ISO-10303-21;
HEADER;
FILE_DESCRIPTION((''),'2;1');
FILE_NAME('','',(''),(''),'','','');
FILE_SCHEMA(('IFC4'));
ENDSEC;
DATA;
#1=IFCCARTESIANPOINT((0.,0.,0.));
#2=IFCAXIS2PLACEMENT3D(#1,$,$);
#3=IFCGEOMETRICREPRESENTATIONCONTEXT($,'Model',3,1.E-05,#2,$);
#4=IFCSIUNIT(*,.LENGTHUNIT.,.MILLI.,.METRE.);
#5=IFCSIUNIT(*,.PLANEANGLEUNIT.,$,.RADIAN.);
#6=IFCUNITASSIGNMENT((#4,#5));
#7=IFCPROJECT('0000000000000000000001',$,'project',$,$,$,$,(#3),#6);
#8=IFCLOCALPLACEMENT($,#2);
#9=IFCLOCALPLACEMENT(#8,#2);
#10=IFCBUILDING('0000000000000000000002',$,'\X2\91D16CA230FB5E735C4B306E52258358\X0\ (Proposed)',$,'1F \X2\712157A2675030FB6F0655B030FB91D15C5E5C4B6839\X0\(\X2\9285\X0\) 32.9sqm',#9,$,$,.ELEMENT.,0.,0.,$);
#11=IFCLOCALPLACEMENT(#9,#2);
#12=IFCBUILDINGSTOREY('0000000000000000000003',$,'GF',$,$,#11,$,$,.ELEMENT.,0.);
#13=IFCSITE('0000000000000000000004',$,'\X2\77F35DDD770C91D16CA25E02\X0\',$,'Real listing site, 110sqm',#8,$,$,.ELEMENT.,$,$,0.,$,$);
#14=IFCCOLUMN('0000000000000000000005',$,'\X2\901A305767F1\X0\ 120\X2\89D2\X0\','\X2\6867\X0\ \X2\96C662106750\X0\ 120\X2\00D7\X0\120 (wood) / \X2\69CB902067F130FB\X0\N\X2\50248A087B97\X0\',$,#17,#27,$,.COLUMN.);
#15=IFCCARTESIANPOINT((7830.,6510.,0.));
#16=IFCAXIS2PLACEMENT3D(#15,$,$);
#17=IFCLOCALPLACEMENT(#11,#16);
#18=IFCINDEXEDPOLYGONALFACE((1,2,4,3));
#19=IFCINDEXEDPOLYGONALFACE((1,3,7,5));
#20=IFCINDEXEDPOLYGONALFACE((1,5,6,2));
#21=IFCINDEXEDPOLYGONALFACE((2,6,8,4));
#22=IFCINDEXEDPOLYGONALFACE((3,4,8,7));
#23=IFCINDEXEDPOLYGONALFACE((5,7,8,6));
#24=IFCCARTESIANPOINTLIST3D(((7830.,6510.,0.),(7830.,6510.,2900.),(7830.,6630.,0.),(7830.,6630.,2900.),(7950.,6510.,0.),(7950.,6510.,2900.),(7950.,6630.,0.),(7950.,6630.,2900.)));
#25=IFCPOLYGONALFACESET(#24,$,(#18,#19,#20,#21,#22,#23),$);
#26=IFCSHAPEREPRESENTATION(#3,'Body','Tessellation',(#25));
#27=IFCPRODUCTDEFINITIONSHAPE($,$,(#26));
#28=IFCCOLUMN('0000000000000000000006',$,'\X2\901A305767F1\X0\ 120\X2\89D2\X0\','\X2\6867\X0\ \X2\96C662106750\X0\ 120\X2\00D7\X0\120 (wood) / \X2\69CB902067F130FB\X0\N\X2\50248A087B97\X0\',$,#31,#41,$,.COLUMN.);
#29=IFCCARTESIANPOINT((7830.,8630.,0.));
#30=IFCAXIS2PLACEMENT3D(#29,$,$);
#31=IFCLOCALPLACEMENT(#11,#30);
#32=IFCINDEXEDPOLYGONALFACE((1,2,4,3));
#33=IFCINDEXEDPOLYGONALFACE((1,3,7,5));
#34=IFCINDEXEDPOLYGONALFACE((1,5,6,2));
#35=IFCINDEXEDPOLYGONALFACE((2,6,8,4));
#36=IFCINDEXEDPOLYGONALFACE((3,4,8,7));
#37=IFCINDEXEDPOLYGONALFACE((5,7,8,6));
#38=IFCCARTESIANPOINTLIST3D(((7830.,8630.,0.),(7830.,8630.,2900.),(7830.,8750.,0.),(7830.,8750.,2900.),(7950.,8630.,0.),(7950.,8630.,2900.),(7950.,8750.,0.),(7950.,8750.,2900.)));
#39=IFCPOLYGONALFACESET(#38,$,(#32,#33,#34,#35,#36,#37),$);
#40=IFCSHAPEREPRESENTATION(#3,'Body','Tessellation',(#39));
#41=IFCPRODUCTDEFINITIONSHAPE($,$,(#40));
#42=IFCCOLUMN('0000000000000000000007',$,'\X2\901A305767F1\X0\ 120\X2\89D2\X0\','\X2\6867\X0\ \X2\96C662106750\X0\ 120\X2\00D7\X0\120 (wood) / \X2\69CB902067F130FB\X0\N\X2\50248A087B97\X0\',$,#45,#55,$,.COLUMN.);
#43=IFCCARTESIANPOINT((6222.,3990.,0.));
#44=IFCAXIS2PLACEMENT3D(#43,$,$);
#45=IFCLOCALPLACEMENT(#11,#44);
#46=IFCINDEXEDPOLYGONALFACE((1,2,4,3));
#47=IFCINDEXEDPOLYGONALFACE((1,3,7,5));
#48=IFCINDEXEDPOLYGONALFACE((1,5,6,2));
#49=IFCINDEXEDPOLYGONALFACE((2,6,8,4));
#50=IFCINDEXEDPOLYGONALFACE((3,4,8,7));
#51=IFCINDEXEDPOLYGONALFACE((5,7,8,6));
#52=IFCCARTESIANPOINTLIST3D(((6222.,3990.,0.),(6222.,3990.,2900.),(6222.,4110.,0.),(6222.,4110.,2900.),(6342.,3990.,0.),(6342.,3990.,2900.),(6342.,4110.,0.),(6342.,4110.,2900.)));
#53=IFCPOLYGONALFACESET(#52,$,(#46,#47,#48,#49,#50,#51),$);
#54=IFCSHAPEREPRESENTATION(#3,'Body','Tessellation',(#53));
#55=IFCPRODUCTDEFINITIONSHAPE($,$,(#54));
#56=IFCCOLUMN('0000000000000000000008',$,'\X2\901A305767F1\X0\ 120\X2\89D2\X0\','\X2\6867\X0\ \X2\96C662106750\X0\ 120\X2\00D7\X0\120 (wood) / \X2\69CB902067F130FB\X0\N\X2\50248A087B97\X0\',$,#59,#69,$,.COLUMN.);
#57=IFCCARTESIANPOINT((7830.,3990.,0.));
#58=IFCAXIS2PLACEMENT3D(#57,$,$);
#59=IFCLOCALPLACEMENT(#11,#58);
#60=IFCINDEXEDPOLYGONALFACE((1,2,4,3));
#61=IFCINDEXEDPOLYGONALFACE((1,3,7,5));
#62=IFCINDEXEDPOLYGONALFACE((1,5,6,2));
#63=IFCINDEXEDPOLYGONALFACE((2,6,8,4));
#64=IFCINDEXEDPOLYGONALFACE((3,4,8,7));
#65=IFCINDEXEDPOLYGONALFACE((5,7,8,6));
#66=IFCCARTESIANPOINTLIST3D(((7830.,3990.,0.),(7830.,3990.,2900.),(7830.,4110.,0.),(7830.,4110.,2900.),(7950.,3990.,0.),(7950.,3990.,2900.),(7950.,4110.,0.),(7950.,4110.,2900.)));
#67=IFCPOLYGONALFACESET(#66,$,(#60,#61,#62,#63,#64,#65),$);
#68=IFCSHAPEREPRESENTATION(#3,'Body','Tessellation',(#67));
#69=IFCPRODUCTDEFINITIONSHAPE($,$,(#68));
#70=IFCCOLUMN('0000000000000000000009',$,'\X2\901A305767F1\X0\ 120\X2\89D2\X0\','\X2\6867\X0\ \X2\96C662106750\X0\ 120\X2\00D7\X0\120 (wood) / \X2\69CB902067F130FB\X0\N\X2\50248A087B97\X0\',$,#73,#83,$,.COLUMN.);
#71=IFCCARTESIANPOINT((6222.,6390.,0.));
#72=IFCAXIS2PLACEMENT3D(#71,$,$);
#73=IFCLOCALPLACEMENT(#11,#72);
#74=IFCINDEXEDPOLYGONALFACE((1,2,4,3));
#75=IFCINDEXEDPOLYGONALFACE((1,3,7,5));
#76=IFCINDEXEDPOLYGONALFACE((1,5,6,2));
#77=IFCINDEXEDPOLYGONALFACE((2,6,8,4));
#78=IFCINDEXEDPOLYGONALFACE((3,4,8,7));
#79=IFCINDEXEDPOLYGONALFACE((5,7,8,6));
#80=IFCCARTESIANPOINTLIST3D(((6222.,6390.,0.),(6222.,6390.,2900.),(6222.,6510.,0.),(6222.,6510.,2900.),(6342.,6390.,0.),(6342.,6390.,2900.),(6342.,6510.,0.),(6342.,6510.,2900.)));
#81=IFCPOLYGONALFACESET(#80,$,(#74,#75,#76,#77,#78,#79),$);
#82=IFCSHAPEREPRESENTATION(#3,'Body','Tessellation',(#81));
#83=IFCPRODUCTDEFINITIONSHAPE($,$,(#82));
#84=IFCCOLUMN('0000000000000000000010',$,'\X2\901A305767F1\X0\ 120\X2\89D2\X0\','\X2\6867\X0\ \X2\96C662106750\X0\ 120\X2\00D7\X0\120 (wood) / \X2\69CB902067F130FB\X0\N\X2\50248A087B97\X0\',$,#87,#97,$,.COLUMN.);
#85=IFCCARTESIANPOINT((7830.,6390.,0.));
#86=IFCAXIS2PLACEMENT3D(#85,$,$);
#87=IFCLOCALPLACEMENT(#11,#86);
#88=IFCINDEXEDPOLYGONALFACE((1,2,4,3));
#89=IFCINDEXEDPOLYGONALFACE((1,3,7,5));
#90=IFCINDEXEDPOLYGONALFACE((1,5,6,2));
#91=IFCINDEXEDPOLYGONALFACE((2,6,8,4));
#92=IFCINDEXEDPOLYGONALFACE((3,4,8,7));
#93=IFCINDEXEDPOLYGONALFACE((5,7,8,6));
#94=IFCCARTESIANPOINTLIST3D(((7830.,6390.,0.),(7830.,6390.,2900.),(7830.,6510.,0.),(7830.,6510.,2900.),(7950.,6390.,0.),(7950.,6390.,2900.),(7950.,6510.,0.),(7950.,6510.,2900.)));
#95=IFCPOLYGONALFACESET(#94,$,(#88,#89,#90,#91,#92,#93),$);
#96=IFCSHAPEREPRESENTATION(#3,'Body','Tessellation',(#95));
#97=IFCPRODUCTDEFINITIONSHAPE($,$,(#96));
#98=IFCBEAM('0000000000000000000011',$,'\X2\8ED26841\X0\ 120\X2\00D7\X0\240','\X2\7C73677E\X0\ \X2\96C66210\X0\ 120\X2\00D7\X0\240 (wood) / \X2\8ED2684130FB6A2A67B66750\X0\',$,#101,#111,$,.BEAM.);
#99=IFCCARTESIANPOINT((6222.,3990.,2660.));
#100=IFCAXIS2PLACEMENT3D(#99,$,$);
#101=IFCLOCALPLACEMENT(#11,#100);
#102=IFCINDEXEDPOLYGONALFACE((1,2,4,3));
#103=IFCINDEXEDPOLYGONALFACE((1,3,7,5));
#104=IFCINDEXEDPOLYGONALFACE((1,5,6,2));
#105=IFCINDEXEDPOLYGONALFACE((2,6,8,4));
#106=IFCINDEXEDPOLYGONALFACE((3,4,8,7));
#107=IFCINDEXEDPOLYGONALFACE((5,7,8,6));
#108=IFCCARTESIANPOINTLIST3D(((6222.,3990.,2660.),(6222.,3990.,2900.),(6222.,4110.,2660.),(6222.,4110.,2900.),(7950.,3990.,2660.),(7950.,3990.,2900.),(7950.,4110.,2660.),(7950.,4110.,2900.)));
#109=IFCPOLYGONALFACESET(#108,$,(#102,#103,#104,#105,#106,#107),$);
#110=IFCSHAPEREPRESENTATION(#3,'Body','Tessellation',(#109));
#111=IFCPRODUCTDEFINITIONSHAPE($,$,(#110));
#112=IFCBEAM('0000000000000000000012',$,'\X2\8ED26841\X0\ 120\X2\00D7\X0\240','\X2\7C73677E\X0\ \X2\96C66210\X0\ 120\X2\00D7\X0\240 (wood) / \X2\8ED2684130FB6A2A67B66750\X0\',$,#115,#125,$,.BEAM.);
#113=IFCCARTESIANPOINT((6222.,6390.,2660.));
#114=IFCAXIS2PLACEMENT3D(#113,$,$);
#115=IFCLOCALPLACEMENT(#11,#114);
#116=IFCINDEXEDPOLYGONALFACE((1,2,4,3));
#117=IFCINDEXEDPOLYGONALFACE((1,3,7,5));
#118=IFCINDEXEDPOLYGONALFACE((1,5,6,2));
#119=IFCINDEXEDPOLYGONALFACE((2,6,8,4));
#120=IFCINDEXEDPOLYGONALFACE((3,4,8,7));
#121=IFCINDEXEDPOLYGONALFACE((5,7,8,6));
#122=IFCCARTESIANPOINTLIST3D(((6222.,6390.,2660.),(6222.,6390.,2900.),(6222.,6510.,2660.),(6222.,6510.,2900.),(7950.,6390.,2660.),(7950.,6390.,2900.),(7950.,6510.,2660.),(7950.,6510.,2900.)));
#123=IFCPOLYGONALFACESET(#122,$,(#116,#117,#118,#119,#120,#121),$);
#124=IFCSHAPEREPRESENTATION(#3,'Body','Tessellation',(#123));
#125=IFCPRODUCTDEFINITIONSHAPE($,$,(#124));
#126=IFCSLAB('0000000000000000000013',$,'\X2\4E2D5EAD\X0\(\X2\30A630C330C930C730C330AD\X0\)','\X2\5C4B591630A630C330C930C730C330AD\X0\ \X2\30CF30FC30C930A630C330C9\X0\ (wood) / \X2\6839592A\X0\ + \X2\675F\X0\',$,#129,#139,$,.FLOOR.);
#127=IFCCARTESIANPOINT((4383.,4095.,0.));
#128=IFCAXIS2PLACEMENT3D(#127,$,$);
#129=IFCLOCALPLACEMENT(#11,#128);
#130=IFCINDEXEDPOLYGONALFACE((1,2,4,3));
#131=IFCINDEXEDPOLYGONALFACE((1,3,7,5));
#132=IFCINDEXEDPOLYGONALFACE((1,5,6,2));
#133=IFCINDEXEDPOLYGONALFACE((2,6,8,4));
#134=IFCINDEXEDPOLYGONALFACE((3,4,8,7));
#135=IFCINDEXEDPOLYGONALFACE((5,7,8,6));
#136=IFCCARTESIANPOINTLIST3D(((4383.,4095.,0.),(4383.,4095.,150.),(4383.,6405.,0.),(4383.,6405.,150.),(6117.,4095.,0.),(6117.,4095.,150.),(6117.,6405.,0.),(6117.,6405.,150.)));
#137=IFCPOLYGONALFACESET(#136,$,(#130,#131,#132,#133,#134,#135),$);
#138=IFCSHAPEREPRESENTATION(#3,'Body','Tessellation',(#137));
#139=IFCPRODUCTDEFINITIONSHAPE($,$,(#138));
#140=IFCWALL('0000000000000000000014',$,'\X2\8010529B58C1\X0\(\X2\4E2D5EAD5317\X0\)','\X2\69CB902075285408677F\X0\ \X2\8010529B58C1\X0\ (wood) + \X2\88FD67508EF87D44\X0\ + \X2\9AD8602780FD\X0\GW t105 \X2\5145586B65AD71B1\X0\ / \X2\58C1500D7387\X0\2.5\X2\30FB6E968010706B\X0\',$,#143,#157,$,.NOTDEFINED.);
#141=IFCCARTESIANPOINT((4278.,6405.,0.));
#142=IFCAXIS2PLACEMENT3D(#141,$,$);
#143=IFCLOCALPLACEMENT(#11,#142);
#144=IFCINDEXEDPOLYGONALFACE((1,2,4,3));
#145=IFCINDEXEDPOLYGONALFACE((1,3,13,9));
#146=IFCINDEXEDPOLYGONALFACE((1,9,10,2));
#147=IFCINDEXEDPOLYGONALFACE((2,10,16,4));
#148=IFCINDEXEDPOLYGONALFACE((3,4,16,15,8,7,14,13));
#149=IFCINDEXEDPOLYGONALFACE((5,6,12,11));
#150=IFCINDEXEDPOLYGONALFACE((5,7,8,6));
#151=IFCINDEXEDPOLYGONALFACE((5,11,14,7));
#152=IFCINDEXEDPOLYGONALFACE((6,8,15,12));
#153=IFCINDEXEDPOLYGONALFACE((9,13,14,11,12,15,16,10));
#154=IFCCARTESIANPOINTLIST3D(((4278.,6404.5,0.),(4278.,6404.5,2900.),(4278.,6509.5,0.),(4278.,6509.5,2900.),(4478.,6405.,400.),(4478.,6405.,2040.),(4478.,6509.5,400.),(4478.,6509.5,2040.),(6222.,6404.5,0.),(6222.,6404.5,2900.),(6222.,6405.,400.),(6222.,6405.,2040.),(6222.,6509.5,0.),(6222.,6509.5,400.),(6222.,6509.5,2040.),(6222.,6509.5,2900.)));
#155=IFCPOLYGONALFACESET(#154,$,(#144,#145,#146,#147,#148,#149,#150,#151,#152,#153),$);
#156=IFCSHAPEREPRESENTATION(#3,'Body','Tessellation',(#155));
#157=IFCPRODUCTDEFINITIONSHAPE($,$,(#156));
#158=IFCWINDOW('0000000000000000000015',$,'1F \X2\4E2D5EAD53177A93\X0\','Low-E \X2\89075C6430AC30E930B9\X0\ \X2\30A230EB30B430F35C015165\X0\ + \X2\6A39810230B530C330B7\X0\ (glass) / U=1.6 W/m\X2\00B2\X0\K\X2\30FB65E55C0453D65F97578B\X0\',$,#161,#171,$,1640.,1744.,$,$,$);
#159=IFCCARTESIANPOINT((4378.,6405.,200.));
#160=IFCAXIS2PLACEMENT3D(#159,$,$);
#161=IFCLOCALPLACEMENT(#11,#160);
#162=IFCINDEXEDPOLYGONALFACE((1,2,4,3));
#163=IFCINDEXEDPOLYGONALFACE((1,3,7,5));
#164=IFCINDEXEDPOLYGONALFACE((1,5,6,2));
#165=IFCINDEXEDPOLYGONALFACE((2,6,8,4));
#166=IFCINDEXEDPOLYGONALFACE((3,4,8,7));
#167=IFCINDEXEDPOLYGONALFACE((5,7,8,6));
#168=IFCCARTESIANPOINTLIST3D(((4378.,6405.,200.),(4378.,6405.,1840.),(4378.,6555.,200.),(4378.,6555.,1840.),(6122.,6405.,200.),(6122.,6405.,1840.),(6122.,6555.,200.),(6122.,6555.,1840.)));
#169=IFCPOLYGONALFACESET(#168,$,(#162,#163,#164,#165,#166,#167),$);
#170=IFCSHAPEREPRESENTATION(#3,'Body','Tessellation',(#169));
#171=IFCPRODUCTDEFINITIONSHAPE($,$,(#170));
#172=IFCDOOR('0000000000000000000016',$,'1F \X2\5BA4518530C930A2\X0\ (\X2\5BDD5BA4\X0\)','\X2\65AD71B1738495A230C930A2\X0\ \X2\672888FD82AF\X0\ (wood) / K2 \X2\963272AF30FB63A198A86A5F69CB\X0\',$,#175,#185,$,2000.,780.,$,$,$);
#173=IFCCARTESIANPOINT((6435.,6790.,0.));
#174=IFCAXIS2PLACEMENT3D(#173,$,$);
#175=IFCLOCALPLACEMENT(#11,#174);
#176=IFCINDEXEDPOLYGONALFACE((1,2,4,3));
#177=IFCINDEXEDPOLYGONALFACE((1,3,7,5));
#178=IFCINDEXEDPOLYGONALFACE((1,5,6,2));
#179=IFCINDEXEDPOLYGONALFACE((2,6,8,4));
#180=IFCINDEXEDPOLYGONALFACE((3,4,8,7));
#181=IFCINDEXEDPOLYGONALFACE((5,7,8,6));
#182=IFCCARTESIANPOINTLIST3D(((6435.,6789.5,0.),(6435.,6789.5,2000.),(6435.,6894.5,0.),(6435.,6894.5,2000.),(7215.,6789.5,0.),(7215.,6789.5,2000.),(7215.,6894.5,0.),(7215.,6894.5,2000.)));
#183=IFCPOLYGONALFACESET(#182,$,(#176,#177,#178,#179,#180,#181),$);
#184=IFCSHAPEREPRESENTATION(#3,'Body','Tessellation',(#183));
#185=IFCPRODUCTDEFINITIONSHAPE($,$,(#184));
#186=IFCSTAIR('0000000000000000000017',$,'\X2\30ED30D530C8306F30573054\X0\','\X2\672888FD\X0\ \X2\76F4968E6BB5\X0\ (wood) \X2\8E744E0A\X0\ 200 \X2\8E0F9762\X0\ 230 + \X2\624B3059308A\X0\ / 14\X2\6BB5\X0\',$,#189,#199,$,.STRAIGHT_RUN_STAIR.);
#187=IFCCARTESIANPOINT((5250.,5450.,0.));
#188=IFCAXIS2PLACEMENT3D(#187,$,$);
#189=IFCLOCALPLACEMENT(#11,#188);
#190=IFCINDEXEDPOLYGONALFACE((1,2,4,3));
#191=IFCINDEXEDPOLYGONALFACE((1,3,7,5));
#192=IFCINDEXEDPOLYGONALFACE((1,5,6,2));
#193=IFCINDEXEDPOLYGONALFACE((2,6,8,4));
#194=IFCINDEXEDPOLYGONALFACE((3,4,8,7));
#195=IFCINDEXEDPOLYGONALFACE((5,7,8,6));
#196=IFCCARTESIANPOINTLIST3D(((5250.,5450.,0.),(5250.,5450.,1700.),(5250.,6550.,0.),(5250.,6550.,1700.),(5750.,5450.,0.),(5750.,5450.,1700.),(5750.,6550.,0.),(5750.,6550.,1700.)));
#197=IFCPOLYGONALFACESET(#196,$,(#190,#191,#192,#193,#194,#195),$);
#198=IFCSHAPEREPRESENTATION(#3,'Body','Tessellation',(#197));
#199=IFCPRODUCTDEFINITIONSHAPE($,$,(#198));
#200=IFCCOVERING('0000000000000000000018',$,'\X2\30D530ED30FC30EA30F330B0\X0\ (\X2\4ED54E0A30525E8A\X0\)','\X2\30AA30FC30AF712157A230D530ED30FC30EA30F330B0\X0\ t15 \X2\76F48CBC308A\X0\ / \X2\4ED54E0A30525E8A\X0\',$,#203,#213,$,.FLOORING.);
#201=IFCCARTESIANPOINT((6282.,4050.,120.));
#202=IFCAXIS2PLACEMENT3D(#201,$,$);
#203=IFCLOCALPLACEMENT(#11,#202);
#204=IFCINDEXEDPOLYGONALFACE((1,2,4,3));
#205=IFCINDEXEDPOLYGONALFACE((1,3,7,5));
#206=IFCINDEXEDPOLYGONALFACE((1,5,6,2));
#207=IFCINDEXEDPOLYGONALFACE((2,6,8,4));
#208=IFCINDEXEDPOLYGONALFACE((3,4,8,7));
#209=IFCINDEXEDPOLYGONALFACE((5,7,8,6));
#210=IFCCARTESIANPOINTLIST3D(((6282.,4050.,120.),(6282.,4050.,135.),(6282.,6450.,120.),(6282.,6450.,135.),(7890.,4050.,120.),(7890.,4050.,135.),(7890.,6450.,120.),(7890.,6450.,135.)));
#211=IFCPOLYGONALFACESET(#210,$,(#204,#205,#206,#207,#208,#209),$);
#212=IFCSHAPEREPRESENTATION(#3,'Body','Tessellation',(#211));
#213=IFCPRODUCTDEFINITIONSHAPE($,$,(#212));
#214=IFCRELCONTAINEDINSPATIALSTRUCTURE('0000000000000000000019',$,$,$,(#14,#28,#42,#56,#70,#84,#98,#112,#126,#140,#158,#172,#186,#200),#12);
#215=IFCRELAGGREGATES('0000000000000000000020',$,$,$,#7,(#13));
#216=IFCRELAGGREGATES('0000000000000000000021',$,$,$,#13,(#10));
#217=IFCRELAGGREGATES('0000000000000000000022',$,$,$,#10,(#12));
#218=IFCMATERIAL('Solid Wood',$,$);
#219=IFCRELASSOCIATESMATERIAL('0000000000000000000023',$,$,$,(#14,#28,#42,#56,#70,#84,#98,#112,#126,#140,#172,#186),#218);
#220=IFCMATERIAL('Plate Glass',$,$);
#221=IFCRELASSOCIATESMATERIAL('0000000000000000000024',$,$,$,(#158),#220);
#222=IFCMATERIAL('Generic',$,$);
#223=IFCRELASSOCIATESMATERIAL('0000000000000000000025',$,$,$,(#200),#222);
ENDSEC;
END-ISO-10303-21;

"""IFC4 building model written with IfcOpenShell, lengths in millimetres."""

from ifc_helpers import new_model, si_unit, frame, frame_2d, origin, place, context, project, spatial, rectangle, extrude, material, element, fill, save


model = new_model("IFC4")

# Units and contexts
model_context = context("Model", 3, precision=1e-05, world=origin())
ifc_project = project(units=[si_unit("LENGTHUNIT", "METRE", prefix="MILLI"), si_unit("PLANEANGLEUNIT", "RADIAN")], contexts=[model_context])

# Site, building, storey
site_placement = place(None, origin())
site = spatial("IfcSite", under=ifc_project, at=site_placement, Name="石川県金沢市", ObjectType="Real listing site, 110sqm", CompositionType="ELEMENT", RefElevation=0.0)
building_placement = place(site_placement, origin())
building = spatial("IfcBuilding", under=site, at=building_placement, Name="金沢・平屋の別荘 (Proposed)", ObjectType="1F 無垢材・漆喰・金属屋根(銅) 32.9sqm", CompositionType="ELEMENT", ElevationOfRefHeight=0.0, ElevationOfTerrain=0.0)
storey_placement = place(building_placement, origin())
storey = spatial("IfcBuildingStorey", under=building, at=storey_placement, Name="GF", CompositionType="ELEMENT", Elevation=0.0)

# Columns
ifc_material_1 = material(Name="Solid Wood")
column_1_placement = place(storey_placement, frame((7830.0, 6510.0, 0.0)))
element("IfcColumn", 1, at=column_1_placement, inside=storey, material=ifc_material_1, Name="通し柱 120角", Description="桧 集成材 120×120 (wood) / 構造柱・N値計算", PredefinedType="COLUMN", context=model_context, shape_type="SweptSolid", body=[
    extrude(rectangle(XDim=120.0, YDim=120.0, at=frame_2d((60.0, 60.0))), frame((7830.0, 6510.0, 0.0)), (0.0, 0.0, 1.0), 2900.0),
])
column_2_placement = place(storey_placement, frame((7830.0, 8630.0, 0.0)))
element("IfcColumn", 2, at=column_2_placement, inside=storey, material=ifc_material_1, Name="通し柱 120角", Description="桧 集成材 120×120 (wood) / 構造柱・N値計算", PredefinedType="COLUMN", context=model_context, shape_type="SweptSolid", body=[
    extrude(rectangle(XDim=120.0, YDim=120.0, at=frame_2d((60.0, 60.0))), frame((7830.0, 8630.0, 0.0)), (0.0, 0.0, 1.0), 2900.0),
])
column_3_placement = place(storey_placement, frame((6222.0, 3990.0, 0.0)))
element("IfcColumn", 3, at=column_3_placement, inside=storey, material=ifc_material_1, Name="通し柱 120角", Description="桧 集成材 120×120 (wood) / 構造柱・N値計算", PredefinedType="COLUMN", context=model_context, shape_type="SweptSolid", body=[
    extrude(rectangle(XDim=120.0, YDim=120.0, at=frame_2d((60.0, 60.0))), frame((6222.0, 3990.0, 0.0)), (0.0, 0.0, 1.0), 2900.0),
])
column_4_placement = place(storey_placement, frame((7830.0, 3990.0, 0.0)))
element("IfcColumn", 4, at=column_4_placement, inside=storey, material=ifc_material_1, Name="通し柱 120角", Description="桧 集成材 120×120 (wood) / 構造柱・N値計算", PredefinedType="COLUMN", context=model_context, shape_type="SweptSolid", body=[
    extrude(rectangle(XDim=120.0, YDim=120.0, at=frame_2d((60.0, 60.0))), frame((7830.0, 3990.0, 0.0)), (0.0, 0.0, 1.0), 2900.0),
])
column_5_placement = place(storey_placement, frame((6222.0, 6390.0, 0.0)))
element("IfcColumn", 5, at=column_5_placement, inside=storey, material=ifc_material_1, Name="通し柱 120角", Description="桧 集成材 120×120 (wood) / 構造柱・N値計算", PredefinedType="COLUMN", context=model_context, shape_type="SweptSolid", body=[
    extrude(rectangle(XDim=120.0, YDim=120.0, at=frame_2d((60.0, 60.0))), frame((6222.0, 6390.0, 0.0)), (0.0, 0.0, 1.0), 2900.0),
])
column_6_placement = place(storey_placement, frame((7830.0, 6390.0, 0.0)))
element("IfcColumn", 6, at=column_6_placement, inside=storey, material=ifc_material_1, Name="通し柱 120角", Description="桧 集成材 120×120 (wood) / 構造柱・N値計算", PredefinedType="COLUMN", context=model_context, shape_type="SweptSolid", body=[
    extrude(rectangle(XDim=120.0, YDim=120.0, at=frame_2d((60.0, 60.0))), frame((7830.0, 6390.0, 0.0)), (0.0, 0.0, 1.0), 2900.0),
])

# Beams
beam_1_placement = place(storey_placement, frame((6222.0, 3990.0, 2660.0)))
element("IfcBeam", 7, at=beam_1_placement, inside=storey, material=ifc_material_1, Name="軒桁 120×240", Description="米松 集成 120×240 (wood) / 軒桁・横架材", PredefinedType="BEAM", context=model_context, shape_type="SweptSolid", body=[
    extrude(rectangle(XDim=1728.0, YDim=120.0, at=frame_2d((864.0, 60.0))), frame((6222.0, 3990.0, 2660.0)), (0.0, 0.0, 1.0), 240.0),
])
beam_2_placement = place(storey_placement, frame((6222.0, 6390.0, 2660.0)))
element("IfcBeam", 8, at=beam_2_placement, inside=storey, material=ifc_material_1, Name="軒桁 120×240", Description="米松 集成 120×240 (wood) / 軒桁・横架材", PredefinedType="BEAM", context=model_context, shape_type="SweptSolid", body=[
    extrude(rectangle(XDim=1728.0, YDim=120.0, at=frame_2d((864.0, 60.0))), frame((6222.0, 6390.0, 2660.0)), (0.0, 0.0, 1.0), 240.0),
])

# Slab
slab_placement = place(storey_placement, frame((4383.0, 4095.0, 0.0)))
element("IfcSlab", 9, at=slab_placement, inside=storey, material=ifc_material_1, Name="中庭(ウッドデッキ)", Description="屋外ウッドデッキ ハードウッド (wood) / 根太 + 束", PredefinedType="FLOOR", context=model_context, shape_type="SweptSolid", body=[
    extrude(rectangle(XDim=1734.0, YDim=2310.0, at=frame_2d((867.0, 1155.0))), frame((4383.0, 4095.0, 0.0)), (0.0, 0.0, 1.0), 150.0),
])

# Wall, opening, window
wall_1_placement = place(storey_placement, frame((4278.0, 6405.0, 0.0)))
wall_1 = element("IfcWall", 10, at=wall_1_placement, inside=storey, material=ifc_material_1, Name="耐力壁(中庭北)", Description="構造用合板 耐力壁 (wood) + 製材軸組 + 高性能GW t105 充填断熱 / 壁倍率2.5・準耐火", PredefinedType="NOTDEFINED", context=model_context, shape_type="SweptSolid", body=[
    extrude(rectangle(XDim=1944.0, YDim=105.0, at=frame_2d((972.0, 52.0))), frame((4278.0, 6405.0, 0.0)), (0.0, 0.0, 1.0), 2900.0),
])
opening_placement = place(storey_placement, frame((4378.0, 6405.0, 200.0)))
opening = element("IfcOpeningElement", 11, at=opening_placement, cuts=wall_1, PredefinedType="NOTDEFINED", context=model_context, shape_type="SweptSolid", body=[
    extrude(rectangle(XDim=1744.0, YDim=150.0, at=frame_2d((872.0, 75.0))), frame((4378.0, 6405.0, 200.0)), (0.0, 0.0, 1.0), 1640.0),
])
ifc_material_2 = material(Name="Plate Glass")
window_placement = place(storey_placement, frame((4378.0, 6405.0, 200.0)))
window = element("IfcWindow", 12, at=window_placement, inside=storey, material=ifc_material_2, Name="1F 中庭北窓", Description="Low-E 複層ガラス アルゴン封入 + 樹脂サッシ (glass) / U=1.6 W/m²K・日射取得型", OverallHeight=1640.0, OverallWidth=1744.0, context=model_context, shape_type="SweptSolid", body=[
    extrude(rectangle(XDim=1744.0, YDim=150.0, at=frame_2d((872.0, 75.0))), frame((4378.0, 6405.0, 200.0)), (0.0, 0.0, 1.0), 1640.0),
])
fill(opening, window)

# Door
door_placement = place(storey_placement, frame((6435.0, 6790.0, 0.0)))
element("IfcDoor", 13, at=door_placement, inside=storey, material=ifc_material_1, Name="1F 室内ドア (寝室)", Description="断熱玄関ドア 木製芯 (wood) / K2 防犯・採風機構", OverallHeight=2000.0, OverallWidth=780.0, context=model_context, shape_type="SweptSolid", body=[
    extrude(rectangle(XDim=780.0, YDim=105.0, at=frame_2d((390.0, 52.0))), frame((6435.0, 6790.0, 0.0)), (0.0, 0.0, 1.0), 2000.0),
])

# Stair
stair_placement = place(storey_placement, frame((5250.0, 5450.0, 0.0)))
element("IfcStair", 14, at=stair_placement, inside=storey, material=ifc_material_1, Name="ロフトはしご", Description="木製 直階段 (wood) 蹴上 200 踏面 230 + 手すり / 14段", PredefinedType="STRAIGHT_RUN_STAIR", context=model_context, shape_type="SweptSolid", body=[
    extrude(rectangle(XDim=500.0, YDim=1100.0, at=frame_2d((250.0, 550.0))), frame((5250.0, 5450.0, 0.0)), (0.0, 0.0, 1.0), 1700.0),
])

# Covering
ifc_material_3 = material(Name="Generic")
covering_placement = place(storey_placement, frame((6282.0, 4050.0, 120.0)))
element("IfcCovering", 15, at=covering_placement, inside=storey, material=ifc_material_3, Name="フローリング (仕上げ床)", Description="オーク無垢フローリング t15 直貼り / 仕上げ床", PredefinedType="FLOORING", context=model_context, shape_type="SweptSolid", body=[
    extrude(rectangle(XDim=1608.0, YDim=2400.0, at=frame_2d((804.0, 1200.0))), frame((6282.0, 4050.0, 120.0)), (0.0, 0.0, 1.0), 15.0),
])

save(model, "model.ifc")
